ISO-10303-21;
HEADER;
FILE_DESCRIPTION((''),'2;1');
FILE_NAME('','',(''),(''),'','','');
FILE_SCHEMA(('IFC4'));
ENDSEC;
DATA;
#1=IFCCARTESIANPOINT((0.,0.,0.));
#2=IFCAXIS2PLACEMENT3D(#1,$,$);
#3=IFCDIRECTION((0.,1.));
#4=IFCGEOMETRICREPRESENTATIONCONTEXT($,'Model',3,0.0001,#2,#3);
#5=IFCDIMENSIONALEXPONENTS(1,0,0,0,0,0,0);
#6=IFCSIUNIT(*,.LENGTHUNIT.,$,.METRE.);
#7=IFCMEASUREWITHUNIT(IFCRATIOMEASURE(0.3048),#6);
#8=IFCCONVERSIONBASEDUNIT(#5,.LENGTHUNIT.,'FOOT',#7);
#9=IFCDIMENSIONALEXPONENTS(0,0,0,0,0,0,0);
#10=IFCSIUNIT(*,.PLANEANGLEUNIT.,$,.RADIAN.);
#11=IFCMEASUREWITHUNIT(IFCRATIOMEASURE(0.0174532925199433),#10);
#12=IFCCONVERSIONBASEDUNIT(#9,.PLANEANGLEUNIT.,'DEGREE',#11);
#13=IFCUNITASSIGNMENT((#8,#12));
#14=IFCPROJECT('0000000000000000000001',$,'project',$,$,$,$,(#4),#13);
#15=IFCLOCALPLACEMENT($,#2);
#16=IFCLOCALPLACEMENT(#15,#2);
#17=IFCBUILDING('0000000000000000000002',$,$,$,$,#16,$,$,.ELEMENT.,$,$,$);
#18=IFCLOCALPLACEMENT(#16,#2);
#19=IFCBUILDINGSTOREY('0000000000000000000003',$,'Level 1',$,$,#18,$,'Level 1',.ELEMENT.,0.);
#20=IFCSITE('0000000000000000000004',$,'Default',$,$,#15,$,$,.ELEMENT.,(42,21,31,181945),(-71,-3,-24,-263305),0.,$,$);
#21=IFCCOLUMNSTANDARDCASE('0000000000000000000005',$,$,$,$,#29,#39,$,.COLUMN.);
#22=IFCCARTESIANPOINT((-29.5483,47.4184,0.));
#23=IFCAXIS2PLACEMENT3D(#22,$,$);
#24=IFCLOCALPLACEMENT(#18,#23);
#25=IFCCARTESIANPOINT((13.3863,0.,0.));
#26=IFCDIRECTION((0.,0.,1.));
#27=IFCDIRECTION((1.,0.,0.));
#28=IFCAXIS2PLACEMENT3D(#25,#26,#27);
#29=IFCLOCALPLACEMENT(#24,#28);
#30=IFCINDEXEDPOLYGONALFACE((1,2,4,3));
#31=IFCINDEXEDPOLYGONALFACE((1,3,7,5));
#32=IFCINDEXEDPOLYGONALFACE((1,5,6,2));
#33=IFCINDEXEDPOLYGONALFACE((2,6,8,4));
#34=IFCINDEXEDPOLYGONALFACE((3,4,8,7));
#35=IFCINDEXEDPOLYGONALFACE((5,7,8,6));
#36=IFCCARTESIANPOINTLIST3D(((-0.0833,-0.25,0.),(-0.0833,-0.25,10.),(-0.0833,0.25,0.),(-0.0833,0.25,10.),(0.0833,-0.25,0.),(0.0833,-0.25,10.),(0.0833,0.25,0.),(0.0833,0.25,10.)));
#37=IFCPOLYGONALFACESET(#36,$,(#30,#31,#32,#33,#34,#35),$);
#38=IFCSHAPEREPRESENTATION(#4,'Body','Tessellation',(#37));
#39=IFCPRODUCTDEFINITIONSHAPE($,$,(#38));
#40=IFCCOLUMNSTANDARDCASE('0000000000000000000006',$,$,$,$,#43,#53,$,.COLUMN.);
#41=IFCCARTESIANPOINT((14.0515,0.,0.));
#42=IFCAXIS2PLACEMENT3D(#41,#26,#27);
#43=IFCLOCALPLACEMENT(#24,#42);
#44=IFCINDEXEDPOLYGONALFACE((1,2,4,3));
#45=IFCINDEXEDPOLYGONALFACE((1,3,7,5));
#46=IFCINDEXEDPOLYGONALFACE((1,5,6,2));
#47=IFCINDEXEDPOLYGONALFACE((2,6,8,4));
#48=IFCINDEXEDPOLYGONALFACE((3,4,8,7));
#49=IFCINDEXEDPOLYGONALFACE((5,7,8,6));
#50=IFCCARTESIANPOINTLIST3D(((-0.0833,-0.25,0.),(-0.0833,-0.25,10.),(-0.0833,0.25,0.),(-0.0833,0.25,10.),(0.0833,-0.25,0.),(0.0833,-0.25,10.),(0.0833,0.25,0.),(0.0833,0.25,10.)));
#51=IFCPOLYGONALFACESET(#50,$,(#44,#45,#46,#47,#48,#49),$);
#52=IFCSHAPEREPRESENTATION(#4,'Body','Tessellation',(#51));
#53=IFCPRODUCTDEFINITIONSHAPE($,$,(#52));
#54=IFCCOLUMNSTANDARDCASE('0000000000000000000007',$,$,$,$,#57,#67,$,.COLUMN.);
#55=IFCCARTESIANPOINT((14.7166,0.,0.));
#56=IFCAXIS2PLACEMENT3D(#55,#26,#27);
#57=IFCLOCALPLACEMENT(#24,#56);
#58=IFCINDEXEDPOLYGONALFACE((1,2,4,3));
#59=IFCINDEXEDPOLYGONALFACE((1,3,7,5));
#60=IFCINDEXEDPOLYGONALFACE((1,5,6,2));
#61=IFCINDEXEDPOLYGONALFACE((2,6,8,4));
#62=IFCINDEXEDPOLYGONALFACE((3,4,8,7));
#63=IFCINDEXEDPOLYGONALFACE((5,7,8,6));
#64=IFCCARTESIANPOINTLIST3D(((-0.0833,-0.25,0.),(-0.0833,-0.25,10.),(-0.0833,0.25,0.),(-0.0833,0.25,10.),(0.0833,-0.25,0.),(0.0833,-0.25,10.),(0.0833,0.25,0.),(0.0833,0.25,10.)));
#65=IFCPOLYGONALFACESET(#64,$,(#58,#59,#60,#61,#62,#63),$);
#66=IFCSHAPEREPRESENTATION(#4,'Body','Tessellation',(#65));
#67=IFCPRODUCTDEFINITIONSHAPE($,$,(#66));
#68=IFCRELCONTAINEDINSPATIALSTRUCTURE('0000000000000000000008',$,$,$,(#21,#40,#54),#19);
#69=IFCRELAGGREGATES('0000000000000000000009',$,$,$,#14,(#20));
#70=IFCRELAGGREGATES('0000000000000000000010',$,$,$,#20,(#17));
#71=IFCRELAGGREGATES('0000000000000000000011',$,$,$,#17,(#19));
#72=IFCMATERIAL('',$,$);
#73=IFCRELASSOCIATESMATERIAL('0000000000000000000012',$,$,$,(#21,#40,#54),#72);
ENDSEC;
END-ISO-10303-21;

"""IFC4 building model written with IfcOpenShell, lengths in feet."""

from ifc_helpers import new_model, entity, si_unit, converted_unit, direction, frame, origin, place, context, project, spatial, rectangle, extrude, material, element, save


model = new_model("IFC4")

# Units and contexts
model_context = context("Model", 3, precision=0.0001, world=origin(), true_north=direction((0.0, 1.0)))
ifc_project = project(units=[converted_unit("LENGTHUNIT", "FOOT", entity("IfcRatioMeasure", 0.3048), si_unit("LENGTHUNIT", "METRE"), dimensions=[1, 0, 0, 0, 0, 0, 0]), converted_unit("PLANEANGLEUNIT", "DEGREE", entity("IfcRatioMeasure", 0.0174532925199433), si_unit("PLANEANGLEUNIT", "RADIAN"), dimensions=[0, 0, 0, 0, 0, 0, 0])], contexts=[model_context])

# Site, building, storey
site_placement = place(None, origin())
site = spatial("IfcSite", under=ifc_project, at=site_placement, Name="Default", CompositionType="ELEMENT", RefLatitude=(42, 21, 31, 181945), RefLongitude=(-71, -3, -24, -263305), RefElevation=0.0)
building_placement = place(site_placement, origin())
building = spatial("IfcBuilding", under=site, at=building_placement, CompositionType="ELEMENT")
storey_placement = place(building_placement, origin())
storey = spatial("IfcBuildingStorey", under=building, at=storey_placement, Name="Level 1", LongName="Level 1", CompositionType="ELEMENT", Elevation=0.0)

# Columns
ifc_material = material(Name="")
placement = place(storey_placement, frame((-29.5483, 47.4184, 0.0)))
for number, where, z_axis, x_axis in (
    (1, (13.3863, 0.0, 0.0), (0.0, 0.0, 1.0), (1.0, 0.0, 0.0)),
    (2, (14.0515, 0.0, 0.0), (0.0, 0.0, 1.0), (1.0, 0.0, 0.0)),
    (3, (14.7166, 0.0, 0.0), (0.0, 0.0, 1.0), (1.0, 0.0, 0.0)),
):
    element("IfcColumnStandardCase", number, at=place(placement, frame(where, z_axis=z_axis, x_axis=x_axis)), inside=storey, material=ifc_material, PredefinedType="COLUMN", context=model_context, shape_type="SweptSolid", body=[
        extrude(rectangle(XDim=0.1667, YDim=0.5), origin(), (0.0, 0.0, 1.0), 10.0),
    ])

save(model, "model.ifc")
